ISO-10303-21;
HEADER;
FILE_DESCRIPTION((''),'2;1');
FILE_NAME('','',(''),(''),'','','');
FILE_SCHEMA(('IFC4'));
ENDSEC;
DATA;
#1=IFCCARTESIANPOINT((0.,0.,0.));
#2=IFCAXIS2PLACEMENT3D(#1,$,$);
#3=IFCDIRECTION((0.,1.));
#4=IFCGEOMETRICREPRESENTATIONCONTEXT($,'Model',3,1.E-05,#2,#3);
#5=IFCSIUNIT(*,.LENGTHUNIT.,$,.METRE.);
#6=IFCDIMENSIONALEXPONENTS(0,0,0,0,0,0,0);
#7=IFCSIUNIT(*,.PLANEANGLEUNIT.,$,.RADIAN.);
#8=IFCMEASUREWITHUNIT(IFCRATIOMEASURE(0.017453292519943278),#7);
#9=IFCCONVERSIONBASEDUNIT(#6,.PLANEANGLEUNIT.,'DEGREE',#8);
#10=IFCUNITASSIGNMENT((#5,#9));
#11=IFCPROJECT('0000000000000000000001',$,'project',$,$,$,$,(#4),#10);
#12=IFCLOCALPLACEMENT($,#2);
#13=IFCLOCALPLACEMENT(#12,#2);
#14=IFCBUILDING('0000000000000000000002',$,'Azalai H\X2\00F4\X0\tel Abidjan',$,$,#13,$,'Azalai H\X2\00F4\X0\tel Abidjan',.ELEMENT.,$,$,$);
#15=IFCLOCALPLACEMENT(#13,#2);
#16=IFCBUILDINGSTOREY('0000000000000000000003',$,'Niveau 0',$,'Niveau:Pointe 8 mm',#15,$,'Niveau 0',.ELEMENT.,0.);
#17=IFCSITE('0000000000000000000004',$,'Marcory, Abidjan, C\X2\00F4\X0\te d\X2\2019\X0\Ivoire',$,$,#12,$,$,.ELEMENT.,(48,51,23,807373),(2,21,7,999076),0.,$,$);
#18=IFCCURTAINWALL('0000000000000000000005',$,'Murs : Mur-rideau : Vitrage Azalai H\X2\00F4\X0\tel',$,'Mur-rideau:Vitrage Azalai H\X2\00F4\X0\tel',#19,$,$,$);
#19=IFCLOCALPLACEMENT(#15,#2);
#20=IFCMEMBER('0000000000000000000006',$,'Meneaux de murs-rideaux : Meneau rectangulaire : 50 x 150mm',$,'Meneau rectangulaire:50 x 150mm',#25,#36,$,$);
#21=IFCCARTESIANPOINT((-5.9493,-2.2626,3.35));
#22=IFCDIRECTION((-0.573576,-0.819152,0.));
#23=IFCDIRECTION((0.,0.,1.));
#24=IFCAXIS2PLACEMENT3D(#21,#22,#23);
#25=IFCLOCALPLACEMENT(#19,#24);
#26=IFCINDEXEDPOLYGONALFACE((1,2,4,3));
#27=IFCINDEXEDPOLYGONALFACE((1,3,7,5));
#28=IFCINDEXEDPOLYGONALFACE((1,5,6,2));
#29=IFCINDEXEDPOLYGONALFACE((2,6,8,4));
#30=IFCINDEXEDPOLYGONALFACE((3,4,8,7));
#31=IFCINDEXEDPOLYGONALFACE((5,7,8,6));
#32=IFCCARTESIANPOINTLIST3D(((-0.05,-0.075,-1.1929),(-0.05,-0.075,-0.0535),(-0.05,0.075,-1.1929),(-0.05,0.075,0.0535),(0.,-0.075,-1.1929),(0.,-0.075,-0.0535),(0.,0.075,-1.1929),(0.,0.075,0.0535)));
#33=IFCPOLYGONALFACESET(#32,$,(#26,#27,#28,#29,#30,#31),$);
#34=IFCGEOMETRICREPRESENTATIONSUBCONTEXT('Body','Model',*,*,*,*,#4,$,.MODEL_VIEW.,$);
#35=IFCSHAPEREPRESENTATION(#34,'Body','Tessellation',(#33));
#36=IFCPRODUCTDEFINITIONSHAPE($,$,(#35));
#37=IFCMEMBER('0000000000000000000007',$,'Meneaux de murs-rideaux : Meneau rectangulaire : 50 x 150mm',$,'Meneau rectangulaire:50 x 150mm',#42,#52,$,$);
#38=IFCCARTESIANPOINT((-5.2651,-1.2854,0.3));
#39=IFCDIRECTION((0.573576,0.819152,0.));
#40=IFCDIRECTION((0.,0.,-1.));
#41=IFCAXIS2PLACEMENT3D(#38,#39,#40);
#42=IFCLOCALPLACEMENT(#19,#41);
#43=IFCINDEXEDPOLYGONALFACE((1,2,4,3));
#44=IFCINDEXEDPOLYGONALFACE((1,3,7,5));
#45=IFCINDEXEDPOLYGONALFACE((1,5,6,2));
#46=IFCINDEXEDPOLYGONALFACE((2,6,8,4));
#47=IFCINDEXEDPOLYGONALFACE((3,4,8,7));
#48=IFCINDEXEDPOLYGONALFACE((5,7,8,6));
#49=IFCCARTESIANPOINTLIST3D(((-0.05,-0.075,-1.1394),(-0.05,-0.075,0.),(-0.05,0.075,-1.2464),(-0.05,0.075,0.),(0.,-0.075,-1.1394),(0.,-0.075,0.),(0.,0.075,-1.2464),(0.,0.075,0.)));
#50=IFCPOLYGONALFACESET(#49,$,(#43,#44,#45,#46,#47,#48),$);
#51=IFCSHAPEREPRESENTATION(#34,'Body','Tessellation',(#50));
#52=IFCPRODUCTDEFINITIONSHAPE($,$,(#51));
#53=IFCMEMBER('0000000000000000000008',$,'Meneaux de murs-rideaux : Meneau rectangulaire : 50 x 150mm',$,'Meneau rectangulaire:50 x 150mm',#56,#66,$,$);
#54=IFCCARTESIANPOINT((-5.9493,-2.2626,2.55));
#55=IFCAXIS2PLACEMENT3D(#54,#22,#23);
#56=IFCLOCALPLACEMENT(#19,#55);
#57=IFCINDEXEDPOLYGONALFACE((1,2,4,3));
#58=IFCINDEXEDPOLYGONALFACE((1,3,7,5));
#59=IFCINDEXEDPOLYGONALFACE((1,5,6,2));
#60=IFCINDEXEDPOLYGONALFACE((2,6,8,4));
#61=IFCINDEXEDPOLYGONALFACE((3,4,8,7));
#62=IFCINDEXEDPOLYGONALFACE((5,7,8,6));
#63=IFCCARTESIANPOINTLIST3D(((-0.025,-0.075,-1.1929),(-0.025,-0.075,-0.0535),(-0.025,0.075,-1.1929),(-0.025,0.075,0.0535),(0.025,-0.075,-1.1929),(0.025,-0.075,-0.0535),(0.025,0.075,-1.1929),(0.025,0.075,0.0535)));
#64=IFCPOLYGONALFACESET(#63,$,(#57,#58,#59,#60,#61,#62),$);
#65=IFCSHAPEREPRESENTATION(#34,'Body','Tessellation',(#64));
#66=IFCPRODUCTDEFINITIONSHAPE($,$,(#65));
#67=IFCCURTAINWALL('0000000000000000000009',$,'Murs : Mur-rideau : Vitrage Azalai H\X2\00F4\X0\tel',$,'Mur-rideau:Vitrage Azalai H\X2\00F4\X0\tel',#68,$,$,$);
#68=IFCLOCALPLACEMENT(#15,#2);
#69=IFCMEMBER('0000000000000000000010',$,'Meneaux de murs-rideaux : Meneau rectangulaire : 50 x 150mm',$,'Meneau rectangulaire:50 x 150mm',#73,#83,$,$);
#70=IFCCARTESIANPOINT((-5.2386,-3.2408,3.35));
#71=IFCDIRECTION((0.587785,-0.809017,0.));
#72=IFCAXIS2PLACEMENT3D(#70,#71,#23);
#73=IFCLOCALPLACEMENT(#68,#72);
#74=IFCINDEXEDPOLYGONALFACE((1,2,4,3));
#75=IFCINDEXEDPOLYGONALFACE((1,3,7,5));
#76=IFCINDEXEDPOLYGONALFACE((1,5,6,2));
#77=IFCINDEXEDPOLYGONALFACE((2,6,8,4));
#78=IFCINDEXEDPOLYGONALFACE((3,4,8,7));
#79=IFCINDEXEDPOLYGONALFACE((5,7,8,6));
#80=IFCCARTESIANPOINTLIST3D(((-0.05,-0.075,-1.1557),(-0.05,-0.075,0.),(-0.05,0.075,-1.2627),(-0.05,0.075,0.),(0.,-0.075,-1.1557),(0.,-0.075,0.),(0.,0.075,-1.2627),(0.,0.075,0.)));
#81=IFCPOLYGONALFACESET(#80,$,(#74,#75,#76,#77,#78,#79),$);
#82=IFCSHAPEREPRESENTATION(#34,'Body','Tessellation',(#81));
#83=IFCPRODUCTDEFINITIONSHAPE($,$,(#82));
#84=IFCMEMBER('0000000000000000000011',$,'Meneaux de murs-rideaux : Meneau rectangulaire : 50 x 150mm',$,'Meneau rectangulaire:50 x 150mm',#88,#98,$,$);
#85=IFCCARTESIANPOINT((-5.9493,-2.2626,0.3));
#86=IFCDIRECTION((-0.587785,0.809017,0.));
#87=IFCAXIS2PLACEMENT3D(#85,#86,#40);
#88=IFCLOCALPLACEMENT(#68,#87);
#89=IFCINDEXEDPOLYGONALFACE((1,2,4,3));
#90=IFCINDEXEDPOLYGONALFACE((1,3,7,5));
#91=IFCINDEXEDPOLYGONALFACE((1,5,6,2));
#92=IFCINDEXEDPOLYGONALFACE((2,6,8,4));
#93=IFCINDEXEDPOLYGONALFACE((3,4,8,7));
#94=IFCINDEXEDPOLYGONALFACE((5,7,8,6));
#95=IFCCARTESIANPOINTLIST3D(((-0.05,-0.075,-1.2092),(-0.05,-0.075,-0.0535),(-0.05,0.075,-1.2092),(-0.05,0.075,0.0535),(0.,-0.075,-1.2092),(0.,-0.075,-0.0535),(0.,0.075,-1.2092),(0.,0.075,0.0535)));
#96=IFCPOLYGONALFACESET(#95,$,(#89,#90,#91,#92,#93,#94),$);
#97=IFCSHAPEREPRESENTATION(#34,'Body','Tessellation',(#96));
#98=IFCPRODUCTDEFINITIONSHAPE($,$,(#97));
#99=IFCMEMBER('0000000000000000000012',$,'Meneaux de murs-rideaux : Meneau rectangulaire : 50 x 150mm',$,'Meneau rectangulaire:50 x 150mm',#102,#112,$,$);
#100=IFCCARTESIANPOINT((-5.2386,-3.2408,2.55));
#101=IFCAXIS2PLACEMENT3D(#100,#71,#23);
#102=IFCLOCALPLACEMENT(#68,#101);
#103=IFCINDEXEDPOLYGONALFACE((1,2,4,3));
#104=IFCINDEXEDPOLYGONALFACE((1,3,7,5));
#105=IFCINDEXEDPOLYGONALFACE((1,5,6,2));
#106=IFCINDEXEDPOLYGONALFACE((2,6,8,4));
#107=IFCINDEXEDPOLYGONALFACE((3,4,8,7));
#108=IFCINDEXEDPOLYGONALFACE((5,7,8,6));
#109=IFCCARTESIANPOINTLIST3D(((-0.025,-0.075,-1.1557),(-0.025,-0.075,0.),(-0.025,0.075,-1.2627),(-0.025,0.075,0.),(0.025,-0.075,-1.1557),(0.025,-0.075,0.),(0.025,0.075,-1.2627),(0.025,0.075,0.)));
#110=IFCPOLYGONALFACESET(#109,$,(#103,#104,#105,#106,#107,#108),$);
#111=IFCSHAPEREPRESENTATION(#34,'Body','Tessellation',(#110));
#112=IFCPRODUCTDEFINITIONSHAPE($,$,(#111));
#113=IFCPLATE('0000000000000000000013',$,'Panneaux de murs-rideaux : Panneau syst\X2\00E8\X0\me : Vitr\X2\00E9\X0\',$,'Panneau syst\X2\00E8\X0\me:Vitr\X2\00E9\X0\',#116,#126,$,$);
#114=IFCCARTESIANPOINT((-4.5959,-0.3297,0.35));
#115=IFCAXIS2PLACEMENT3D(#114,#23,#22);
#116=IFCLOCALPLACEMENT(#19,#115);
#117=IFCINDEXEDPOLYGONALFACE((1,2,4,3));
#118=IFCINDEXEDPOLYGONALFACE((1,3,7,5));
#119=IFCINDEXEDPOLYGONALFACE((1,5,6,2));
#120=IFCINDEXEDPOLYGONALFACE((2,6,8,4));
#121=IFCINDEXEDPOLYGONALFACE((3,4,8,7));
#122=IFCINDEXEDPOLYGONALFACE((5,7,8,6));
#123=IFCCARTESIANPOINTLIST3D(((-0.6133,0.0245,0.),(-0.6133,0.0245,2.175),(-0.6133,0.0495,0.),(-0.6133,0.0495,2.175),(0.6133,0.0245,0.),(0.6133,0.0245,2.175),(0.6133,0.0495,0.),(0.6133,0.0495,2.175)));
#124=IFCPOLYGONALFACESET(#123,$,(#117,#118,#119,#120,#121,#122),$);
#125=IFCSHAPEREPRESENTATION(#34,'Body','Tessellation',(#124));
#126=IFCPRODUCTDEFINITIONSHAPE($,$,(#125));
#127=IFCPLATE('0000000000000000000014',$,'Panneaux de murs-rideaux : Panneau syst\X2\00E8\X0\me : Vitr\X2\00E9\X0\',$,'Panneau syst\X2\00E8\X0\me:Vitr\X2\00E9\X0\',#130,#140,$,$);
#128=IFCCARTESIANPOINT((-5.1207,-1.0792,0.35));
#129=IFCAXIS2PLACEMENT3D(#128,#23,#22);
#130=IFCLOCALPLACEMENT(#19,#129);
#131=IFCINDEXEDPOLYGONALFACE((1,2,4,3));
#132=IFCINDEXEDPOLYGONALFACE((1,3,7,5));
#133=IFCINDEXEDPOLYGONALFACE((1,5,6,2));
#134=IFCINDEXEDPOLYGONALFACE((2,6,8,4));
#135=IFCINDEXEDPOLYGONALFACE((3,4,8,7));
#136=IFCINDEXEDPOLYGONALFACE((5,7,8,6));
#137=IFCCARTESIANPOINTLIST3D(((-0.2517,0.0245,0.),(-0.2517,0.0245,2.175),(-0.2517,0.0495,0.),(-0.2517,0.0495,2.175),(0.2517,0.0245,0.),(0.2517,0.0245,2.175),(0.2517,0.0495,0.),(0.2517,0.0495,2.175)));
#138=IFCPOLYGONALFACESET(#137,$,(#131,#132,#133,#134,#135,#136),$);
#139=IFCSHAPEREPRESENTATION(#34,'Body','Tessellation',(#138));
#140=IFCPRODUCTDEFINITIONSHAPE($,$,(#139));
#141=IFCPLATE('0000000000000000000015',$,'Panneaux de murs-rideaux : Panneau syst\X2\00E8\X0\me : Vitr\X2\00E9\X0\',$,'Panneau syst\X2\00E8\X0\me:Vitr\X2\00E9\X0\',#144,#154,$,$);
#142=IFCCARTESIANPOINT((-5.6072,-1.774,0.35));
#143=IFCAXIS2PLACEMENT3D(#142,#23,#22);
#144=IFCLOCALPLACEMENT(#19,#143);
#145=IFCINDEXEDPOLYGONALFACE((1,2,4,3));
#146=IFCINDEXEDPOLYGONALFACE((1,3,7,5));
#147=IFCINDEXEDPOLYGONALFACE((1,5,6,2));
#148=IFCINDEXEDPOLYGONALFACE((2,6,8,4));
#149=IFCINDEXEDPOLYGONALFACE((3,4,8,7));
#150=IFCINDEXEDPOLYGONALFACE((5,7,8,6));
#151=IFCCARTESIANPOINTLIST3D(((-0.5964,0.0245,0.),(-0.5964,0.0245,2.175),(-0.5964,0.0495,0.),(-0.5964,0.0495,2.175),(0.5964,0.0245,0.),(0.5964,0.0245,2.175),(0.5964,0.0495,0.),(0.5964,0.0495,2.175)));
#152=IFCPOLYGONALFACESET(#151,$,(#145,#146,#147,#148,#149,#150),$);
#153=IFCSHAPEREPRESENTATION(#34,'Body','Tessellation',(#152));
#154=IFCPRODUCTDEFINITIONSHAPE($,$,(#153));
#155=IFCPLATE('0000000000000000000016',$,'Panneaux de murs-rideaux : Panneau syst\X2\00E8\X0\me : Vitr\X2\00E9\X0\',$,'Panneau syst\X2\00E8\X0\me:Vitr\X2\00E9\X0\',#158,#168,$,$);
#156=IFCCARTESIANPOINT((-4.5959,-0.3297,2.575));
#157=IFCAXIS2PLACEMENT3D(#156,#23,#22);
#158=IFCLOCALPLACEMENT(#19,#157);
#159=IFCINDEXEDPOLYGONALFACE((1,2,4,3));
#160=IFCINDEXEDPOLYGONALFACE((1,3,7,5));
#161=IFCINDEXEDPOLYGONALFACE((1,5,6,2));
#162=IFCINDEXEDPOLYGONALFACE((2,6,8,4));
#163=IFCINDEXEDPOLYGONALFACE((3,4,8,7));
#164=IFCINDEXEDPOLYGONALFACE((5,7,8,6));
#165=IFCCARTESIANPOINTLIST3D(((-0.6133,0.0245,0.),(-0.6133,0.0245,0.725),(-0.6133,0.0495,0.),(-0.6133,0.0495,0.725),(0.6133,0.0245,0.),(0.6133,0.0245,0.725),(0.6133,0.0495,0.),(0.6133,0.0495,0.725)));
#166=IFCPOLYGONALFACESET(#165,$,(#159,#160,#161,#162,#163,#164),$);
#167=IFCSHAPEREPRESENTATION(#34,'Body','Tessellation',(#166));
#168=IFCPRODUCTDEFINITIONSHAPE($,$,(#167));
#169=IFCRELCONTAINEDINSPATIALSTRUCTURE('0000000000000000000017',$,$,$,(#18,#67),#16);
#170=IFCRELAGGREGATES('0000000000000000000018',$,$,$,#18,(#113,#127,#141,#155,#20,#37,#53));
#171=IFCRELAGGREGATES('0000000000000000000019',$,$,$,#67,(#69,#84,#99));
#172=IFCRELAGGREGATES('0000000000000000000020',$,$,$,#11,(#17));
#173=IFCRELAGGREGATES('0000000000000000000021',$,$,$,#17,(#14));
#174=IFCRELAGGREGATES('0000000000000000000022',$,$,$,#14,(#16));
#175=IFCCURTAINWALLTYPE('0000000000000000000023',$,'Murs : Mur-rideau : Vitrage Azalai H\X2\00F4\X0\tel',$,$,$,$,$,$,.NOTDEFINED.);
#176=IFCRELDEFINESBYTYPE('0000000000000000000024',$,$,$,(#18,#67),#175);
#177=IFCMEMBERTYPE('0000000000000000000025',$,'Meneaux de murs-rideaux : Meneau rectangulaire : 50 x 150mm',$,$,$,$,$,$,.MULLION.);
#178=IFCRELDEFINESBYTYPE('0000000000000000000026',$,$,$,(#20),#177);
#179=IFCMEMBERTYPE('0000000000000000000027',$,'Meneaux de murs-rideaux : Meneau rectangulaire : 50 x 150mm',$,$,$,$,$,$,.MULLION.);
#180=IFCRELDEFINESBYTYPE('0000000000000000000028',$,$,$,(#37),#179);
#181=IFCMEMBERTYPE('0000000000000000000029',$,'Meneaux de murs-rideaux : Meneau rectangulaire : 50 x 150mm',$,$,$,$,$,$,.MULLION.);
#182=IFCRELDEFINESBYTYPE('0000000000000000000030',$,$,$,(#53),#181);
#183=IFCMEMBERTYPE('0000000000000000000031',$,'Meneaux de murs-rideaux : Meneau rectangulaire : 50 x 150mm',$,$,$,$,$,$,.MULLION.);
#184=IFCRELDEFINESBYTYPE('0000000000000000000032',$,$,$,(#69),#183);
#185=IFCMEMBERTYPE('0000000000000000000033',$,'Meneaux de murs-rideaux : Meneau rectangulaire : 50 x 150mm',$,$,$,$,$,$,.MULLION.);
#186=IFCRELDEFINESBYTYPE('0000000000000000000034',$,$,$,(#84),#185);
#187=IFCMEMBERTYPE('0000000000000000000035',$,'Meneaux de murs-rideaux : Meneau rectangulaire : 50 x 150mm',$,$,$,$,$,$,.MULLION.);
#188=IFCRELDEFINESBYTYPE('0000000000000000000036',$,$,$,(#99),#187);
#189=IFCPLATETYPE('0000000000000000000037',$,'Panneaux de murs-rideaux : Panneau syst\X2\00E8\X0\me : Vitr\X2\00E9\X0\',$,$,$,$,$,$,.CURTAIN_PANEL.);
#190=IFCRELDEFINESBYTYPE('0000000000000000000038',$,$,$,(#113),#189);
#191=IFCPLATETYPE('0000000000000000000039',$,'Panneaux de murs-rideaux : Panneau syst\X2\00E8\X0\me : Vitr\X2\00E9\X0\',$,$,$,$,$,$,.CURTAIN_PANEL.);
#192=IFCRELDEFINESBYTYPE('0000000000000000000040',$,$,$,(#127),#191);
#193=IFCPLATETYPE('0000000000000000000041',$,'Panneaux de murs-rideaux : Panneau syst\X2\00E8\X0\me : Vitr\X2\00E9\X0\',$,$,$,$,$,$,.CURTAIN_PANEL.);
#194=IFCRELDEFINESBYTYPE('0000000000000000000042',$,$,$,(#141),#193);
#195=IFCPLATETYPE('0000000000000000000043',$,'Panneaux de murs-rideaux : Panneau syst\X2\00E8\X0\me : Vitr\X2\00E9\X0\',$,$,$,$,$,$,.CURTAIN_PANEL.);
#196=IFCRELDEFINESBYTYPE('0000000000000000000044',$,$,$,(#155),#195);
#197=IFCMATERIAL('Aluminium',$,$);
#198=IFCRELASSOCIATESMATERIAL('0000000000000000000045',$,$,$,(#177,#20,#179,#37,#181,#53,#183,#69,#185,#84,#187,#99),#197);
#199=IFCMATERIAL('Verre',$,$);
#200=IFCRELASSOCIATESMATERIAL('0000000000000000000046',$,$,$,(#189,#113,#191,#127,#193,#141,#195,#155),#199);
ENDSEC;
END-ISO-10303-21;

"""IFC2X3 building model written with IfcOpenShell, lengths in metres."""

from ifc_helpers import new_model, entity, si_unit, converted_unit, direction, frame, frame_2d, origin, origin_2d_with_axis, place, context, subcontext, project, spatial, rectangle, extrude, clip, halfspace, source, transform, mapped, material, type_object, type_shapes, element, aggregate, save


model = new_model("IFC2X3")

# Units and contexts
model_context = context("Model", 3, precision=1e-05, world=origin(), true_north=direction((0.0, 1.0)))
body_context = subcontext(model_context, "Body", "Model", "MODEL_VIEW")
ifc_project = project(units=[si_unit("LENGTHUNIT", "METRE"), converted_unit("PLANEANGLEUNIT", "DEGREE", entity("IfcRatioMeasure", 0.017453292519943278), si_unit("PLANEANGLEUNIT", "RADIAN"), dimensions=[0, 0, 0, 0, 0, 0, 0])], contexts=[model_context])

# Site, building, storey
site_placement = place(None, origin())
site = spatial("IfcSite", under=ifc_project, at=site_placement, Name="Marcory, Abidjan, Côte d’Ivoire", CompositionType="ELEMENT", RefLatitude=(48, 51, 23, 807373), RefLongitude=(2, 21, 7, 999076), RefElevation=0.0)
building_placement = place(site_placement, origin())
building = spatial("IfcBuilding", under=site, at=building_placement, Name="Azalai Hôtel Abidjan", LongName="Azalai Hôtel Abidjan", CompositionType="ELEMENT")
storey_placement = place(building_placement, origin())
storey = spatial("IfcBuildingStorey", under=building, at=storey_placement, Name="Niveau 0", ObjectType="Niveau:Pointe 8 mm", LongName="Niveau 0", CompositionType="ELEMENT", Elevation=0.0)

# Curtain walls, members
curtain_wall_type = type_object("IfcCurtainWallType", Name="Murs : Mur-rideau : Vitrage Azalai Hôtel", PredefinedType="NOTDEFINED")
curtain_wall_1_placement = place(storey_placement, origin())
curtain_wall_1 = element("IfcCurtainWall", 1, at=curtain_wall_1_placement, inside=storey, type_object=curtain_wall_type, Name="Murs : Mur-rideau : Vitrage Azalai Hôtel", ObjectType="Mur-rideau:Vitrage Azalai Hôtel")
ifc_material_1 = material(Name="Aluminium")
member_type_1 = type_object("IfcMemberType", Name="Meneaux de murs-rideaux : Meneau rectangulaire : 50 x 150mm", PredefinedType="MULLION", material=ifc_material_1)
shared_shape_1 = source(origin(), body_context, "Body", "SweptSolid", [
    clip(extrude(rectangle(XDim=0.15, YDim=0.05, at=origin_2d_with_axis()), frame((-0.025, 0.0, -1.1929), z_axis=(0.0, 0.0, 1.0), x_axis=(0.0, -1.0, 0.0)), (0.0, 0.0, 1.0), 1.2464), halfspace(frame((0.3048, 0.0, 0.0), z_axis=(0.0, -0.580703, 0.814116), x_axis=(0.0, -0.814116, -0.580703)), False)),
])
type_shapes(member_type_1, [shared_shape_1])
member_1_placement = place(curtain_wall_1_placement, frame((-5.9493, -2.2626, 3.35), z_axis=(-0.573576, -0.819152, 0.0), x_axis=(0.0, 0.0, 1.0)))
member_1 = element("IfcMember", 2, at=member_1_placement, type_object=member_type_1, material=ifc_material_1, Name="Meneaux de murs-rideaux : Meneau rectangulaire : 50 x 150mm", ObjectType="Meneau rectangulaire:50 x 150mm", context=body_context, shape_type="MappedRepresentation", body=[
    mapped(shared_shape_1, transform((0.0, 0.0, 0.0), scale=1.0)),
])
member_type_2 = type_object("IfcMemberType", Name="Meneaux de murs-rideaux : Meneau rectangulaire : 50 x 150mm", PredefinedType="MULLION", material=ifc_material_1)
shared_shape_2 = source(origin(), body_context, "Body", "SweptSolid", [
    clip(extrude(rectangle(XDim=0.15, YDim=0.05, at=origin_2d_with_axis()), frame((-0.025, 0.0, -1.2464), z_axis=(0.0, 0.0, 1.0), x_axis=(0.0, -1.0, 0.0)), (0.0, 0.0, 1.0), 1.2464), halfspace(frame((0.3048, 0.0, -1.1929), z_axis=(0.0, -0.580703, -0.814116), x_axis=(0.0, -0.814116, 0.580703)), False)),
])
type_shapes(member_type_2, [shared_shape_2])
member_2_placement = place(curtain_wall_1_placement, frame((-5.2651, -1.2854, 0.3), z_axis=(0.573576, 0.819152, 0.0), x_axis=(0.0, 0.0, -1.0)))
member_2 = element("IfcMember", 3, at=member_2_placement, type_object=member_type_2, material=ifc_material_1, Name="Meneaux de murs-rideaux : Meneau rectangulaire : 50 x 150mm", ObjectType="Meneau rectangulaire:50 x 150mm", context=body_context, shape_type="MappedRepresentation", body=[
    mapped(shared_shape_2, transform((0.0, 0.0, 0.0), scale=1.0)),
])
member_type_3 = type_object("IfcMemberType", Name="Meneaux de murs-rideaux : Meneau rectangulaire : 50 x 150mm", PredefinedType="MULLION", material=ifc_material_1)
shared_shape_3 = source(origin(), body_context, "Body", "SweptSolid", [
    clip(extrude(rectangle(XDim=0.15, YDim=0.05, at=origin_2d_with_axis()), frame((0.0, 0.0, -1.1929), z_axis=(0.0, 0.0, 1.0), x_axis=(0.0, -1.0, 0.0)), (0.0, 0.0, 1.0), 1.2464), halfspace(frame((0.3048, 0.0, 0.0), z_axis=(0.0, -0.580703, 0.814116), x_axis=(0.0, -0.814116, -0.580703)), False)),
])
type_shapes(member_type_3, [shared_shape_3])
member_3_placement = place(curtain_wall_1_placement, frame((-5.9493, -2.2626, 2.55), z_axis=(-0.573576, -0.819152, 0.0), x_axis=(0.0, 0.0, 1.0)))
member_3 = element("IfcMember", 4, at=member_3_placement, type_object=member_type_3, material=ifc_material_1, Name="Meneaux de murs-rideaux : Meneau rectangulaire : 50 x 150mm", ObjectType="Meneau rectangulaire:50 x 150mm", context=body_context, shape_type="MappedRepresentation", body=[
    mapped(shared_shape_3, transform((0.0, 0.0, 0.0), scale=1.0)),
])
curtain_wall_2_placement = place(storey_placement, origin())
curtain_wall_2 = element("IfcCurtainWall", 5, at=curtain_wall_2_placement, inside=storey, type_object=curtain_wall_type, Name="Murs : Mur-rideau : Vitrage Azalai Hôtel", ObjectType="Mur-rideau:Vitrage Azalai Hôtel")
member_type_4 = type_object("IfcMemberType", Name="Meneaux de murs-rideaux : Meneau rectangulaire : 50 x 150mm", PredefinedType="MULLION", material=ifc_material_1)
shared_shape_4 = source(origin(), body_context, "Body", "SweptSolid", [
    clip(extrude(rectangle(XDim=0.15, YDim=0.05, at=origin_2d_with_axis()), frame((-0.025, 0.0, -1.2627), z_axis=(0.0, 0.0, 1.0), x_axis=(0.0, -1.0, 0.0)), (0.0, 0.0, 1.0), 1.2627), halfspace(frame((0.3048, 0.0, -1.2092), z_axis=(0.0, -0.580703, -0.814116), x_axis=(0.0, -0.814116, 0.580703)), False)),
])
type_shapes(member_type_4, [shared_shape_4])
member_4_placement = place(curtain_wall_2_placement, frame((-5.2386, -3.2408, 3.35), z_axis=(0.587785, -0.809017, 0.0), x_axis=(0.0, 0.0, 1.0)))
member_4 = element("IfcMember", 6, at=member_4_placement, type_object=member_type_4, material=ifc_material_1, Name="Meneaux de murs-rideaux : Meneau rectangulaire : 50 x 150mm", ObjectType="Meneau rectangulaire:50 x 150mm", context=body_context, shape_type="MappedRepresentation", body=[
    mapped(shared_shape_4, transform((0.0, 0.0, 0.0), scale=1.0)),
])
member_type_5 = type_object("IfcMemberType", Name="Meneaux de murs-rideaux : Meneau rectangulaire : 50 x 150mm", PredefinedType="MULLION", material=ifc_material_1)
shared_shape_5 = source(origin(), body_context, "Body", "SweptSolid", [
    clip(extrude(rectangle(XDim=0.15, YDim=0.05, at=origin_2d_with_axis()), frame((-0.025, 0.0, -1.2092), z_axis=(0.0, 0.0, 1.0), x_axis=(0.0, -1.0, 0.0)), (0.0, 0.0, 1.0), 1.2627), halfspace(frame((0.3048, 0.0, 0.0), z_axis=(0.0, -0.580703, 0.814116), x_axis=(0.0, -0.814116, -0.580703)), False)),
])
type_shapes(member_type_5, [shared_shape_5])
member_5_placement = place(curtain_wall_2_placement, frame((-5.9493, -2.2626, 0.3), z_axis=(-0.587785, 0.809017, 0.0), x_axis=(0.0, 0.0, -1.0)))
member_5 = element("IfcMember", 7, at=member_5_placement, type_object=member_type_5, material=ifc_material_1, Name="Meneaux de murs-rideaux : Meneau rectangulaire : 50 x 150mm", ObjectType="Meneau rectangulaire:50 x 150mm", context=body_context, shape_type="MappedRepresentation", body=[
    mapped(shared_shape_5, transform((0.0, 0.0, 0.0), scale=1.0)),
])
member_type_6 = type_object("IfcMemberType", Name="Meneaux de murs-rideaux : Meneau rectangulaire : 50 x 150mm", PredefinedType="MULLION", material=ifc_material_1)
shared_shape_6 = source(origin(), body_context, "Body", "SweptSolid", [
    clip(extrude(rectangle(XDim=0.15, YDim=0.05, at=origin_2d_with_axis()), frame((0.0, 0.0, -1.2627), z_axis=(0.0, 0.0, 1.0), x_axis=(0.0, -1.0, 0.0)), (0.0, 0.0, 1.0), 1.2627), halfspace(frame((0.3048, 0.0, -1.2092), z_axis=(0.0, -0.580703, -0.814116), x_axis=(0.0, -0.814116, 0.580703)), False)),
])
type_shapes(member_type_6, [shared_shape_6])
member_6_placement = place(curtain_wall_2_placement, frame((-5.2386, -3.2408, 2.55), z_axis=(0.587785, -0.809017, 0.0), x_axis=(0.0, 0.0, 1.0)))
member_6 = element("IfcMember", 8, at=member_6_placement, type_object=member_type_6, material=ifc_material_1, Name="Meneaux de murs-rideaux : Meneau rectangulaire : 50 x 150mm", ObjectType="Meneau rectangulaire:50 x 150mm", context=body_context, shape_type="MappedRepresentation", body=[
    mapped(shared_shape_6, transform((0.0, 0.0, 0.0), scale=1.0)),
])

# Plates
ifc_material_2 = material(Name="Verre")
plate_type_1 = type_object("IfcPlateType", Name="Panneaux de murs-rideaux : Panneau système : Vitré", PredefinedType="CURTAIN_PANEL", material=ifc_material_2)
shared_shape_7 = source(origin(), body_context, "Body", "SweptSolid", [
    extrude(rectangle(XDim=0.025, YDim=1.2266, at=frame_2d((0.0, 0.0), x_axis=(1.0, 0.0))), frame((0.0, 0.037, 0.0), z_axis=(0.0, 0.0, 1.0), x_axis=(0.0, 1.0, 0.0)), (0.0, 0.0, 1.0), 2.175),
])
type_shapes(plate_type_1, [shared_shape_7])
plate_1_placement = place(curtain_wall_1_placement, frame((-4.5959, -0.3297, 0.35), z_axis=(0.0, 0.0, 1.0), x_axis=(-0.573576, -0.819152, 0.0)))
plate_1 = element("IfcPlate", 9, at=plate_1_placement, type_object=plate_type_1, material=ifc_material_2, Name="Panneaux de murs-rideaux : Panneau système : Vitré", ObjectType="Panneau système:Vitré", context=body_context, shape_type="MappedRepresentation", body=[
    mapped(shared_shape_7, transform((0.0, 0.0, 0.0), scale=1.0)),
])
plate_type_2 = type_object("IfcPlateType", Name="Panneaux de murs-rideaux : Panneau système : Vitré", PredefinedType="CURTAIN_PANEL", material=ifc_material_2)
shared_shape_8 = source(origin(), body_context, "Body", "SweptSolid", [
    extrude(rectangle(XDim=0.025, YDim=0.5034, at=frame_2d((0.0, 0.0), x_axis=(1.0, 0.0))), frame((0.0, 0.037, 0.0), z_axis=(0.0, 0.0, 1.0), x_axis=(0.0, 1.0, 0.0)), (0.0, 0.0, 1.0), 2.175),
])
type_shapes(plate_type_2, [shared_shape_8])
plate_2_placement = place(curtain_wall_1_placement, frame((-5.1207, -1.0792, 0.35), z_axis=(0.0, 0.0, 1.0), x_axis=(-0.573576, -0.819152, 0.0)))
plate_2 = element("IfcPlate", 10, at=plate_2_placement, type_object=plate_type_2, material=ifc_material_2, Name="Panneaux de murs-rideaux : Panneau système : Vitré", ObjectType="Panneau système:Vitré", context=body_context, shape_type="MappedRepresentation", body=[
    mapped(shared_shape_8, transform((0.0, 0.0, 0.0), scale=1.0)),
])
plate_type_3 = type_object("IfcPlateType", Name="Panneaux de murs-rideaux : Panneau système : Vitré", PredefinedType="CURTAIN_PANEL", material=ifc_material_2)
shared_shape_9 = source(origin(), body_context, "Body", "SweptSolid", [
    extrude(rectangle(XDim=0.025, YDim=1.1929, at=origin_2d_with_axis()), frame((0.0, 0.037, 0.0), z_axis=(0.0, 0.0, 1.0), x_axis=(0.0, 1.0, 0.0)), (0.0, 0.0, 1.0), 2.175),
])
type_shapes(plate_type_3, [shared_shape_9])
plate_3_placement = place(curtain_wall_1_placement, frame((-5.6072, -1.774, 0.35), z_axis=(0.0, 0.0, 1.0), x_axis=(-0.573576, -0.819152, 0.0)))
plate_3 = element("IfcPlate", 11, at=plate_3_placement, type_object=plate_type_3, material=ifc_material_2, Name="Panneaux de murs-rideaux : Panneau système : Vitré", ObjectType="Panneau système:Vitré", context=body_context, shape_type="MappedRepresentation", body=[
    mapped(shared_shape_9, transform((0.0, 0.0, 0.0), scale=1.0)),
])
plate_type_4 = type_object("IfcPlateType", Name="Panneaux de murs-rideaux : Panneau système : Vitré", PredefinedType="CURTAIN_PANEL", material=ifc_material_2)
shared_shape_10 = source(origin(), body_context, "Body", "SweptSolid", [
    extrude(rectangle(XDim=0.025, YDim=1.2266, at=frame_2d((0.0, 0.0), x_axis=(1.0, 0.0))), frame((0.0, 0.037, 0.0), z_axis=(0.0, 0.0, 1.0), x_axis=(0.0, 1.0, 0.0)), (0.0, 0.0, 1.0), 0.725),
])
type_shapes(plate_type_4, [shared_shape_10])
plate_4_placement = place(curtain_wall_1_placement, frame((-4.5959, -0.3297, 2.575), z_axis=(0.0, 0.0, 1.0), x_axis=(-0.573576, -0.819152, 0.0)))
plate_4 = element("IfcPlate", 12, at=plate_4_placement, type_object=plate_type_4, material=ifc_material_2, Name="Panneaux de murs-rideaux : Panneau système : Vitré", ObjectType="Panneau système:Vitré", context=body_context, shape_type="MappedRepresentation", body=[
    mapped(shared_shape_10, transform((0.0, 0.0, 0.0), scale=1.0)),
])
aggregate(curtain_wall_1, [plate_1, plate_2, plate_3, plate_4, member_1, member_2, member_3])
aggregate(curtain_wall_2, [member_4, member_5, member_6])

save(model, "model.ifc")
